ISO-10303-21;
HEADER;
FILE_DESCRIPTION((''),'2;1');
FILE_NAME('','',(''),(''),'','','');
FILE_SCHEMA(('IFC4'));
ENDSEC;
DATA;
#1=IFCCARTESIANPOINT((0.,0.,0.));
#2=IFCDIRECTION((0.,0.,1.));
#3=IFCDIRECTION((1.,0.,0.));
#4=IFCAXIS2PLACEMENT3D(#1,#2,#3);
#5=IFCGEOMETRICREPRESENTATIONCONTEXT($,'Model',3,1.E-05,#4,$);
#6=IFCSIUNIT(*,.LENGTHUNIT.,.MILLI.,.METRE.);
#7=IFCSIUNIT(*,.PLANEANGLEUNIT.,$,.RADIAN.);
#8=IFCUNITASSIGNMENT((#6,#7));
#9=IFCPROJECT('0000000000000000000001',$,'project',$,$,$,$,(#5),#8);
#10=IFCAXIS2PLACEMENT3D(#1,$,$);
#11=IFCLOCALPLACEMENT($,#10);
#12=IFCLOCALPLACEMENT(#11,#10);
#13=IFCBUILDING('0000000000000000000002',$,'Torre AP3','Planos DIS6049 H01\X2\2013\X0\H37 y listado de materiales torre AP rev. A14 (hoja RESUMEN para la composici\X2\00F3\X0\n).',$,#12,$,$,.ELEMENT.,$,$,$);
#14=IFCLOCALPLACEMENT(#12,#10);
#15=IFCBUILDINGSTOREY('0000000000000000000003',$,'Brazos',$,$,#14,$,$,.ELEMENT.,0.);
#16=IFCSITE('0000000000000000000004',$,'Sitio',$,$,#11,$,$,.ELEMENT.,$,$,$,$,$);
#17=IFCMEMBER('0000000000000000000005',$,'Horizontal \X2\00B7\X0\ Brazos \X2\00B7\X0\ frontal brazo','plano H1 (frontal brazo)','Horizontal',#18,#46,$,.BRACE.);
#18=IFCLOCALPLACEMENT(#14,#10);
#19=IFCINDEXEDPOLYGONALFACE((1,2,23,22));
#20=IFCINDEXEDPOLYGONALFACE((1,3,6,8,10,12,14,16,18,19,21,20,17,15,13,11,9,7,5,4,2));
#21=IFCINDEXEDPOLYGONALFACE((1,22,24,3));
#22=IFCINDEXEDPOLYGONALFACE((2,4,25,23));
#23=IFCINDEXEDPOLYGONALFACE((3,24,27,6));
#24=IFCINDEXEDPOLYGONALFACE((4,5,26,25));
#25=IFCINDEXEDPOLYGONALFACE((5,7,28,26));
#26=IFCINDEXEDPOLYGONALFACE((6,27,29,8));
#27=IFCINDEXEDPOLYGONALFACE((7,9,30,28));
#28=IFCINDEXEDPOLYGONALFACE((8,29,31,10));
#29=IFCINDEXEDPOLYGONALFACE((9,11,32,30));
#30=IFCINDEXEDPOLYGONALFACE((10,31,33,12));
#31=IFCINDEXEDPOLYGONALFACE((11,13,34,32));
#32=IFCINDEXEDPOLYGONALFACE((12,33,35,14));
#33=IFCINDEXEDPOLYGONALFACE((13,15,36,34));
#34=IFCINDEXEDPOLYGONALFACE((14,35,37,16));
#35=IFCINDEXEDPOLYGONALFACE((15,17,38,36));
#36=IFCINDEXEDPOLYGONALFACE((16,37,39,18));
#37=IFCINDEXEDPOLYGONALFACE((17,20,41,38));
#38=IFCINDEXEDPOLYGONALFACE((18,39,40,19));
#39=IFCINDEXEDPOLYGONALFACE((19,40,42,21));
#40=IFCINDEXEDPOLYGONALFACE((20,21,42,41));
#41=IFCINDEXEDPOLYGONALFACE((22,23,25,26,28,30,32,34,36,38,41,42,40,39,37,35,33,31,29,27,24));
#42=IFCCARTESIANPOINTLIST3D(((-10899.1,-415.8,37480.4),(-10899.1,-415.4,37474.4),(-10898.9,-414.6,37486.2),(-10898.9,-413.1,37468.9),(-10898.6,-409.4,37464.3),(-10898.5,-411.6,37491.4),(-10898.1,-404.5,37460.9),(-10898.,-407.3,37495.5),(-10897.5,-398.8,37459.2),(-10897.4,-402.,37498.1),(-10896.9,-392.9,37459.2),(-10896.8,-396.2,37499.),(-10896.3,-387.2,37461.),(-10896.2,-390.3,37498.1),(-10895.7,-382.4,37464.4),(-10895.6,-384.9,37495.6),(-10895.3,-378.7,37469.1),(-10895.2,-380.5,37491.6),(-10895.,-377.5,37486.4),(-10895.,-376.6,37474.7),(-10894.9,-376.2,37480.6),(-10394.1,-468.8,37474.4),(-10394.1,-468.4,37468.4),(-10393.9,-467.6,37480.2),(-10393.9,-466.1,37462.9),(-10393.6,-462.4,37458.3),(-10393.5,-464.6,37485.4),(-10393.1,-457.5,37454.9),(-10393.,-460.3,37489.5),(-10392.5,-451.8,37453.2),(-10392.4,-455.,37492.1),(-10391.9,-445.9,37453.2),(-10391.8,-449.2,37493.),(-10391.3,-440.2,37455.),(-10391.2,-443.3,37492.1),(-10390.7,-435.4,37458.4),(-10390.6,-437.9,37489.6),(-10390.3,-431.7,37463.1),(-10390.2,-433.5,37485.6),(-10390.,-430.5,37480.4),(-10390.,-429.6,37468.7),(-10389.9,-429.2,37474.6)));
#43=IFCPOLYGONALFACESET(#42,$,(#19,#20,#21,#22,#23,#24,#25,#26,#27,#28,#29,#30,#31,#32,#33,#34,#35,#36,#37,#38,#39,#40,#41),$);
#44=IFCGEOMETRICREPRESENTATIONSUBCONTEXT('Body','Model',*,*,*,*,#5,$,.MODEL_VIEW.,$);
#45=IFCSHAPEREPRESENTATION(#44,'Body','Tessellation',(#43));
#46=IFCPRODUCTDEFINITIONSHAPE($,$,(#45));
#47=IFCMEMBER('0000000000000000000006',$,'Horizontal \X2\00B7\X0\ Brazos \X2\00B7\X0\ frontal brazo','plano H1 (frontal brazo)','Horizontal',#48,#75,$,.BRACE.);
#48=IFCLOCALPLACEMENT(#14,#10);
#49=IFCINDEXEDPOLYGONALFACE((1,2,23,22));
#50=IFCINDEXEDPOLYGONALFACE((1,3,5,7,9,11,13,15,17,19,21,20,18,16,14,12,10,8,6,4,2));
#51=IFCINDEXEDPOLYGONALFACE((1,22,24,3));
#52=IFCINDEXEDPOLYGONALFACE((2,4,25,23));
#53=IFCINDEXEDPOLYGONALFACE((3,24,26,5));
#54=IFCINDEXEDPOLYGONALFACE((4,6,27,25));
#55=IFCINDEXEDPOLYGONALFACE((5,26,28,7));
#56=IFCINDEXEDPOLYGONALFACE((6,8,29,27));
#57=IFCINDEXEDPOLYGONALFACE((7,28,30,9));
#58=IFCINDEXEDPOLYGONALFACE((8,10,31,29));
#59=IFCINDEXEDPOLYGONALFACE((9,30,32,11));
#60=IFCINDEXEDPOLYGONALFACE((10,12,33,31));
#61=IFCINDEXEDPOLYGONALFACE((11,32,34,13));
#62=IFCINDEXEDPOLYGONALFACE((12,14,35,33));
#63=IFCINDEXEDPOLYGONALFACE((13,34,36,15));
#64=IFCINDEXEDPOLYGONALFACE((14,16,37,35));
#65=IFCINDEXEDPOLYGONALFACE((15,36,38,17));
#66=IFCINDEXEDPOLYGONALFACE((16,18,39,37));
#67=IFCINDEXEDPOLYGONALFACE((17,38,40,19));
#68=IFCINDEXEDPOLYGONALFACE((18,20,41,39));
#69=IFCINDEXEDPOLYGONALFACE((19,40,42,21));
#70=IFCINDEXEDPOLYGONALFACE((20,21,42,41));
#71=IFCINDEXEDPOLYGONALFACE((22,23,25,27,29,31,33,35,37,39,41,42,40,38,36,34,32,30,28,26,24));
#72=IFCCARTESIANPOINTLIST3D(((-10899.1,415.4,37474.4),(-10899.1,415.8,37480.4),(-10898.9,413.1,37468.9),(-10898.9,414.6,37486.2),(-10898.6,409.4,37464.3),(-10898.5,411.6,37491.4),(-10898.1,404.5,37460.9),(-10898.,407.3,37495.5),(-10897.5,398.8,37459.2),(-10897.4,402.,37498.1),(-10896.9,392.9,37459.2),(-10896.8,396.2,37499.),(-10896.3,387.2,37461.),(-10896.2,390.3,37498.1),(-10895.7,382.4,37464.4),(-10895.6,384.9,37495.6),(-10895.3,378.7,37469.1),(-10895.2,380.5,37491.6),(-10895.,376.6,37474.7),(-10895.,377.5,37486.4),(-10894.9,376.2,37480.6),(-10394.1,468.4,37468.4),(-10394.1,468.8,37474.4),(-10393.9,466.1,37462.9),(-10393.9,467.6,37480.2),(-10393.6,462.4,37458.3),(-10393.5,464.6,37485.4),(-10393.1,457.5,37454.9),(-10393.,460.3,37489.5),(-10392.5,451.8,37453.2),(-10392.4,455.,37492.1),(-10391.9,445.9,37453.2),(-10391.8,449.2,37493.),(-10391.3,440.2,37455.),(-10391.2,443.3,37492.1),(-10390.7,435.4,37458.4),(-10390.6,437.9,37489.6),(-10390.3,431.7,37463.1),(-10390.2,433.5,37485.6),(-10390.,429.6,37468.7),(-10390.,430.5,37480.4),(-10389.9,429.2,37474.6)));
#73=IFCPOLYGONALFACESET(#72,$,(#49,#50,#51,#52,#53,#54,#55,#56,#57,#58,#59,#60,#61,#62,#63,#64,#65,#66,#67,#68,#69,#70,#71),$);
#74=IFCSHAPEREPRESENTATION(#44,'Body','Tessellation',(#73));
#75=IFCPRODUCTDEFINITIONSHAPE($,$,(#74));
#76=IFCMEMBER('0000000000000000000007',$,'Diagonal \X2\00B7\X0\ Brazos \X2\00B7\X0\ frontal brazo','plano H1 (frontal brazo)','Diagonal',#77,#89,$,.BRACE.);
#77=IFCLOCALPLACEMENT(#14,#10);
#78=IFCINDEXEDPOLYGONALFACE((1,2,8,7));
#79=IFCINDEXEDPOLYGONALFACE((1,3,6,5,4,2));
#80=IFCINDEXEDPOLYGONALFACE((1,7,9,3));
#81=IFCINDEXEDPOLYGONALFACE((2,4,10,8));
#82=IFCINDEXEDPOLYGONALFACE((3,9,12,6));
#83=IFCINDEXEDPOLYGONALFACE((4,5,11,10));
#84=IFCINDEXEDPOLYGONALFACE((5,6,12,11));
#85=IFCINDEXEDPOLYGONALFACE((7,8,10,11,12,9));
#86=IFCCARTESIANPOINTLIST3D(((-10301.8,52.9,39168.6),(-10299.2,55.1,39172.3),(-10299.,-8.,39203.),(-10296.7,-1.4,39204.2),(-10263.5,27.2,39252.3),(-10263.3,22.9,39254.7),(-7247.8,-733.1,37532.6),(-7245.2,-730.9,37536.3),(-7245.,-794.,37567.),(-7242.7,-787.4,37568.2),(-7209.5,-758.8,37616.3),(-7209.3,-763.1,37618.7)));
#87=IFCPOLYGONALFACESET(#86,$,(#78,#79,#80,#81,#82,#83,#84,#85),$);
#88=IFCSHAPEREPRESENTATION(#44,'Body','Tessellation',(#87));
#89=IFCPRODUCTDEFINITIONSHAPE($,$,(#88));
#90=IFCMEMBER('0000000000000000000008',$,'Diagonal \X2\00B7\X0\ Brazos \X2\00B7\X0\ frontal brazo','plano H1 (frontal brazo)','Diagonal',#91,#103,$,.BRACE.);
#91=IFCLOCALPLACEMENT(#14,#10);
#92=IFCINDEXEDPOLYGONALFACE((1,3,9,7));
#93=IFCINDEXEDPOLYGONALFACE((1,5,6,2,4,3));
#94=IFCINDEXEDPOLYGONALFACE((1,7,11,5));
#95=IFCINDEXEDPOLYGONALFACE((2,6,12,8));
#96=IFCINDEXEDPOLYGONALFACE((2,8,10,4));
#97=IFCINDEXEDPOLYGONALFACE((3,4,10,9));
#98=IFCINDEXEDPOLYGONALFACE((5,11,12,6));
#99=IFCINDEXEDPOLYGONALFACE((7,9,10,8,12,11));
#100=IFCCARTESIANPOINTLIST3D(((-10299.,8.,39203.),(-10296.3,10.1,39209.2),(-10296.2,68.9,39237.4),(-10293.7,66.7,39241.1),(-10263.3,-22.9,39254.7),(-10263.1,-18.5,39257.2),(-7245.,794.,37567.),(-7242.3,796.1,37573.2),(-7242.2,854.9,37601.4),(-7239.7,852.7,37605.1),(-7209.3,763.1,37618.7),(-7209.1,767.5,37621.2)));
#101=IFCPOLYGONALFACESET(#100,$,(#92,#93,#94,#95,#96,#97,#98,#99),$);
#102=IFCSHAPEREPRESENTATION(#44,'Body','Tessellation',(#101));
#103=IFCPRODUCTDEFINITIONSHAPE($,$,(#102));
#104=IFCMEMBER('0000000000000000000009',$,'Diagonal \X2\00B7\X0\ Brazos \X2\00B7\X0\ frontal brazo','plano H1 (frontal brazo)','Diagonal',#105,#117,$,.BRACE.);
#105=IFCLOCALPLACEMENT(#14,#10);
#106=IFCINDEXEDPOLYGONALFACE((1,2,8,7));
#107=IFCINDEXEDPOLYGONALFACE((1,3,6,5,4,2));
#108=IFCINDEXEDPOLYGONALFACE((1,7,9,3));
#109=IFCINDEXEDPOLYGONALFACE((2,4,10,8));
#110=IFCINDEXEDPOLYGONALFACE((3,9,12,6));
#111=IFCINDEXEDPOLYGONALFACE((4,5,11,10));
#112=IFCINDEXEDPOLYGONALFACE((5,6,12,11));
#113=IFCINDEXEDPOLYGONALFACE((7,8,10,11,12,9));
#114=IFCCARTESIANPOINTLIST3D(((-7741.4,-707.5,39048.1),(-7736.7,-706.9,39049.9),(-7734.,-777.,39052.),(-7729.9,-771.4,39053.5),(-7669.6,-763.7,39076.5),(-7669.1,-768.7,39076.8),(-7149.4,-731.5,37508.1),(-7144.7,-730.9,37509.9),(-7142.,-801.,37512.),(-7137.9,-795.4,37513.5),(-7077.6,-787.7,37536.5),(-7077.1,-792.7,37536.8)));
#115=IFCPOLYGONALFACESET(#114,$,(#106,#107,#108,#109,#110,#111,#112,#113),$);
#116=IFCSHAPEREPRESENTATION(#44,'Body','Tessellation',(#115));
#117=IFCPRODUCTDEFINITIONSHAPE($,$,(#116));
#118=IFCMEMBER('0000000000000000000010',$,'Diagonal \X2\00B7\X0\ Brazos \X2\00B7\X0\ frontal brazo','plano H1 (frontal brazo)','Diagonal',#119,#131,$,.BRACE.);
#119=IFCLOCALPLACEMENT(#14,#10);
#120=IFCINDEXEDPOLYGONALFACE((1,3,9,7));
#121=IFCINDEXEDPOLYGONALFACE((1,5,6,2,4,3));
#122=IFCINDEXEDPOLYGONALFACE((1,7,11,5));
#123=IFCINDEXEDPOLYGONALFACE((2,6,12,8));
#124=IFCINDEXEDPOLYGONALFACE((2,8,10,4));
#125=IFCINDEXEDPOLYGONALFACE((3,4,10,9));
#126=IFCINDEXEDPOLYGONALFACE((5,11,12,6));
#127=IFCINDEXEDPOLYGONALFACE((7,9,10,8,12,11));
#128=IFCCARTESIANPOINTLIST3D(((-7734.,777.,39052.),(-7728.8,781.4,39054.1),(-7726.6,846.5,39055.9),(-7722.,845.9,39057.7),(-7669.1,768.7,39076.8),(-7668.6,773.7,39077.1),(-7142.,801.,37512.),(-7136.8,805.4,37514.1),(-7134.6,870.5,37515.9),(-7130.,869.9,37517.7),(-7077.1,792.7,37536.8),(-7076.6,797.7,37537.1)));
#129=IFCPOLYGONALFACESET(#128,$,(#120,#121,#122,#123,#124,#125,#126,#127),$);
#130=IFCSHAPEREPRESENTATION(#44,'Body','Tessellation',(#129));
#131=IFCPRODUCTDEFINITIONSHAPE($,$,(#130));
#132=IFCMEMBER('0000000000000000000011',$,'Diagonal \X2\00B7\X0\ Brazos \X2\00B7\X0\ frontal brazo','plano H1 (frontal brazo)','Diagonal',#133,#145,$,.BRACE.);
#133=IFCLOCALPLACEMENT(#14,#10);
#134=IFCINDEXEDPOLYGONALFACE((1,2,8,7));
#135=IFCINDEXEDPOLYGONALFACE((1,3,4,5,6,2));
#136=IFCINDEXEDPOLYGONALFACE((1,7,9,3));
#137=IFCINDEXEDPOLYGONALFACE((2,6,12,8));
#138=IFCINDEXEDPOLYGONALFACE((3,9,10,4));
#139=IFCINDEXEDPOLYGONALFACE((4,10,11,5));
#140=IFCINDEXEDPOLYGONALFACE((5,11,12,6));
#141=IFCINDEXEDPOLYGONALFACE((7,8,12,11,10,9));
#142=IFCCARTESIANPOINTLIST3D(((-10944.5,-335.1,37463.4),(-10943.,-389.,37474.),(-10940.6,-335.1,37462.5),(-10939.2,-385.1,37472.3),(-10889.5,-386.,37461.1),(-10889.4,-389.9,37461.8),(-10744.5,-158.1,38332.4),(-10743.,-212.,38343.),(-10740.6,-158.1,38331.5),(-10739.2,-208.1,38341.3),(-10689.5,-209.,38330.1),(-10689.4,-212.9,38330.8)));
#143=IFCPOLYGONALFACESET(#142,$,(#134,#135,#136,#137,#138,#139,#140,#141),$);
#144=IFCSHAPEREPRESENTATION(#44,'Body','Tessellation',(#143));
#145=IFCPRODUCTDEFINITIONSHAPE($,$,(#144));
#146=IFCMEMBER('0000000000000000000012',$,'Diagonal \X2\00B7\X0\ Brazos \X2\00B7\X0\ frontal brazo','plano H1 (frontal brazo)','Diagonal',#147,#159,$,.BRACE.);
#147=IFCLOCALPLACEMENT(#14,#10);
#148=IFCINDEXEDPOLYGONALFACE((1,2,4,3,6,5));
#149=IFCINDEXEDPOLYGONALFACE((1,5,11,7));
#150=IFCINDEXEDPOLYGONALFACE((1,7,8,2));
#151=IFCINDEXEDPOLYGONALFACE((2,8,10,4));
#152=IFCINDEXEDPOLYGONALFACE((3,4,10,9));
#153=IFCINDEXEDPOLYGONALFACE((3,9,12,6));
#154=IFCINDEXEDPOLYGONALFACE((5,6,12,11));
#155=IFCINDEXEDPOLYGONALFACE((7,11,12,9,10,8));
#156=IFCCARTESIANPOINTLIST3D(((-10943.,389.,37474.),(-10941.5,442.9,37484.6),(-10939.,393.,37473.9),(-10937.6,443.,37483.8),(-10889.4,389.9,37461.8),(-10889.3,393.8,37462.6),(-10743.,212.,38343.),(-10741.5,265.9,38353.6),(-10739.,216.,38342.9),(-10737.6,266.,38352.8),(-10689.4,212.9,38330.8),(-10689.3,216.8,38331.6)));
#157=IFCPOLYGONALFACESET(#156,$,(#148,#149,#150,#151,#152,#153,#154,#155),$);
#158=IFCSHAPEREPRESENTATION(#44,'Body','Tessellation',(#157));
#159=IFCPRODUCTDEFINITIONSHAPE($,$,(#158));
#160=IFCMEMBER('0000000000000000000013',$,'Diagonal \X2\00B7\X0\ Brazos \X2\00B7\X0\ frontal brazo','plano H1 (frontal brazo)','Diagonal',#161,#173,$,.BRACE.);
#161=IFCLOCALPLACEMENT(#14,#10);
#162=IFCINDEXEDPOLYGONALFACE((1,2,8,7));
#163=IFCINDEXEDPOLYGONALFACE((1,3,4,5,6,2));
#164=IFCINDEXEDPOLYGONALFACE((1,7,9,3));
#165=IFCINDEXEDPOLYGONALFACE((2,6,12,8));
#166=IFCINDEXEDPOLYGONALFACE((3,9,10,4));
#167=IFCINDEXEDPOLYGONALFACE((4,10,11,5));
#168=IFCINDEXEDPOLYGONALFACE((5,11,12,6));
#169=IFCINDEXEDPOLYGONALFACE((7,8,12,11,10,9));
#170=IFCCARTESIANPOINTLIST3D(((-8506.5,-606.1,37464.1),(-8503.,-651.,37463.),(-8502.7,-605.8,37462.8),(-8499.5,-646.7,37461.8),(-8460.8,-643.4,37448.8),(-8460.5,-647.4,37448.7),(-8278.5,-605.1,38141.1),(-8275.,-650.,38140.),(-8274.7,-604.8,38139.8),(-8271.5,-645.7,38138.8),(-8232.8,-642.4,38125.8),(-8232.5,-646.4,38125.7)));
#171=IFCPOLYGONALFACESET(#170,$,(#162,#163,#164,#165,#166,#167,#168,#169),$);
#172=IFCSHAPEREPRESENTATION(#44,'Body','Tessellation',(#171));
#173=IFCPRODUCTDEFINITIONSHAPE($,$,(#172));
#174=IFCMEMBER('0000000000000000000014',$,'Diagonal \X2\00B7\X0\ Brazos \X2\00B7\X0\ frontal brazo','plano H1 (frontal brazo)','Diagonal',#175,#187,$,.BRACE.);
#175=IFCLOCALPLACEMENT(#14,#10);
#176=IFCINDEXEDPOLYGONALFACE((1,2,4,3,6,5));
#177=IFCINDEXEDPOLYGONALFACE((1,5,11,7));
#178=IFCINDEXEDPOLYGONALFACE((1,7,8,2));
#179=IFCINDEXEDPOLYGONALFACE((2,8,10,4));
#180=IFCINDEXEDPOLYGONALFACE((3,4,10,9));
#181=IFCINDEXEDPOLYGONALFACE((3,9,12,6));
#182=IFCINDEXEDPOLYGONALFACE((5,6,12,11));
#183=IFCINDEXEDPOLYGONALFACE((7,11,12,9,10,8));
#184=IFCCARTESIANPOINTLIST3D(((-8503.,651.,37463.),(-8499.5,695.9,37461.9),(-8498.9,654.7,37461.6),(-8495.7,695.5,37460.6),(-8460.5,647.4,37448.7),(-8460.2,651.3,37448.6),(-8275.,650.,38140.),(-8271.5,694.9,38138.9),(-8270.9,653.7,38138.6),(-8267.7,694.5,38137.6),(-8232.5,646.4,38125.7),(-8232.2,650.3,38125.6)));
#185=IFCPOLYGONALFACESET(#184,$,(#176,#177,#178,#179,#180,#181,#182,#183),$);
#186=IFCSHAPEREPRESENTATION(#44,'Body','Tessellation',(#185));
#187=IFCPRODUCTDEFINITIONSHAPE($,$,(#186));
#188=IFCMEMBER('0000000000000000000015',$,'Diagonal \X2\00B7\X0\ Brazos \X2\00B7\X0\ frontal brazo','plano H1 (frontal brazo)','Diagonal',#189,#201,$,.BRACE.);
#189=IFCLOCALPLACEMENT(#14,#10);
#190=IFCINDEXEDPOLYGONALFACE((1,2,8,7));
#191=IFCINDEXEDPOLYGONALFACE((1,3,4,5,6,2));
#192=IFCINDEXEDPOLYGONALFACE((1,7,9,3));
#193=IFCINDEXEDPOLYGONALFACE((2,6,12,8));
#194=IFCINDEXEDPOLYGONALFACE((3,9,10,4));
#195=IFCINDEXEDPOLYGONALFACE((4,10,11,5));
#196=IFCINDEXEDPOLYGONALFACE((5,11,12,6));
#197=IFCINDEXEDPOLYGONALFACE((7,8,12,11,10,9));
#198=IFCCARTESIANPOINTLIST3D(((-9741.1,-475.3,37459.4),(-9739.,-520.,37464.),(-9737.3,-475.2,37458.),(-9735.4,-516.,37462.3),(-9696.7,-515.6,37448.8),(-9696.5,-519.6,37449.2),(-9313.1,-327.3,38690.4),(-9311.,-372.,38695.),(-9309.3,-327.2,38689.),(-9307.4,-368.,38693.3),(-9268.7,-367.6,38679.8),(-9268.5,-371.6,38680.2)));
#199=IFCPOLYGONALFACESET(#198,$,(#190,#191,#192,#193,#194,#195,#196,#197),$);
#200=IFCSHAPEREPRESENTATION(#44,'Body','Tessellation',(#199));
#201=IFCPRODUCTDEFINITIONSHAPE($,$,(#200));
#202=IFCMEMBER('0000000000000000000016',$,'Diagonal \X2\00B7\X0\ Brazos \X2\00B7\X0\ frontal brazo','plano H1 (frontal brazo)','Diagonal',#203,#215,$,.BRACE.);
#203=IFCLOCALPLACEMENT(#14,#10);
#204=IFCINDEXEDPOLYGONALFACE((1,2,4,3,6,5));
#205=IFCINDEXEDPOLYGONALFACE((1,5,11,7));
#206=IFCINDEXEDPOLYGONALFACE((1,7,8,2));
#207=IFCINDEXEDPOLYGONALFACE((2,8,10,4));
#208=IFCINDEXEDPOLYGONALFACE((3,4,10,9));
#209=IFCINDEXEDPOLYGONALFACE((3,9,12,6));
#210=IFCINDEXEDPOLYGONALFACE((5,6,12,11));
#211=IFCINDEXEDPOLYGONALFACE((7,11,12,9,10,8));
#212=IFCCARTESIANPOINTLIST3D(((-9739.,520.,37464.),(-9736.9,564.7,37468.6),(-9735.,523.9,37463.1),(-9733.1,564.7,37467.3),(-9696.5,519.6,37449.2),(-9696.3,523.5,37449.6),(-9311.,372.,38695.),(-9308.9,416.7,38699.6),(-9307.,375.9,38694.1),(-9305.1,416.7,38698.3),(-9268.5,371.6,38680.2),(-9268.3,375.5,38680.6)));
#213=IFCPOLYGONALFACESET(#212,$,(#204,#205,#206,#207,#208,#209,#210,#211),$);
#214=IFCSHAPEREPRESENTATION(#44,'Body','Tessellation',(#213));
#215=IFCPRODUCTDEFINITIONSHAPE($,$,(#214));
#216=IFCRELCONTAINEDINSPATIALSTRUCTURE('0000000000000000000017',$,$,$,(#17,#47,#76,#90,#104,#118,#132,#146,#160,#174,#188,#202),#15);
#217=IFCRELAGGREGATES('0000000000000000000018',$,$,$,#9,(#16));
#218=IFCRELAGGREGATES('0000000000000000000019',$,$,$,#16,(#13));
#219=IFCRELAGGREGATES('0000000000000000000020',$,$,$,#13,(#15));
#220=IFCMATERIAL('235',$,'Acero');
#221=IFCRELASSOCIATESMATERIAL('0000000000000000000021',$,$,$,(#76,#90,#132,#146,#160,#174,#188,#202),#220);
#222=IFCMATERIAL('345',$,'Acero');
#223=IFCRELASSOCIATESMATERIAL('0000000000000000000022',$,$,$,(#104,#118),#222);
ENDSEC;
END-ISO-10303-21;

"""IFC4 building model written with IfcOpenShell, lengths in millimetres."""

from ifc_helpers import new_model, si_unit, frame, frame_2d, origin, origin_with_axes, place, context, subcontext, project, spatial, circle, l_section, extrude, material, element, save


model = new_model("IFC4")

# Units and contexts
model_context = context("Model", 3, precision=1e-05, world=origin_with_axes())
body_context = subcontext(model_context, "Body", "Model", "MODEL_VIEW")
ifc_project = project(units=[si_unit("LENGTHUNIT", "METRE", prefix="MILLI"), si_unit("PLANEANGLEUNIT", "RADIAN")], contexts=[model_context])

# Site, building, storey
site_placement = place(None, origin())
site = spatial("IfcSite", under=ifc_project, at=site_placement, Name="Sitio", CompositionType="ELEMENT")
building_placement = place(site_placement, origin())
building = spatial("IfcBuilding", under=site, at=building_placement, Name="Torre AP3", Description="Planos DIS6049 H01–H37 y listado de materiales torre AP rev. A14 (hoja RESUMEN para la composición).", CompositionType="ELEMENT")
storey_placement = place(building_placement, origin())
storey = spatial("IfcBuildingStorey", under=building, at=storey_placement, Name="Brazos", CompositionType="ELEMENT", Elevation=0.0)

# Members
for number, where, z_axis, x_axis, name in (
    (1, (-10392.0, -449.0, 37473.0), (-0.994468, 0.10437, 0.011815), (0.104986, 0.991163, 0.081074), "Horizontal · Brazos · frontal brazo"),
    (2, (-10392.0, 449.0, 37473.0), (-0.994468, -0.10437, 0.011815), (0.104986, -0.991163, 0.081074), "Horizontal · Brazos · frontal brazo"),
):
    element("IfcMember", number, at=place(storey_placement, frame(where, z_axis=z_axis, x_axis=x_axis)), inside=storey, Name=name, Description="plano H1 (frontal brazo)", ObjectType="Horizontal", PredefinedType="BRACE", context=body_context, shape_type="SweptSolid", body=[
        extrude(circle(Radius=20.0), None, (0.0, 0.0, 1.0), 507.8),
    ])
ifc_material_1 = material(Name="235", Category="Acero")
for number, where, z_axis, x_axis, name in (
    (3, (-7245.0, -794.0, 37567.0), (-0.859644, 0.221244, 0.460503), (0.509345, 0.441284, 0.738808), "Diagonal · Brazos · frontal brazo"),
    (4, (-7245.0, 794.0, 37567.0), (-0.859644, -0.221244, 0.460503), (0.509345, -0.441284, 0.738808), "Diagonal · Brazos · frontal brazo"),
):
    element("IfcMember", number, at=place(storey_placement, frame(where, z_axis=z_axis, x_axis=x_axis)), inside=storey, material=ifc_material_1, Name=name, Description="plano H1 (frontal brazo)", ObjectType="Diagonal", PredefinedType="BRACE", context=body_context, shape_type="SweptSolid", body=[
        extrude(l_section(Depth=70.0, Width=70.0, Thickness=5.0, at=frame_2d((35.0, 35.0))), None, (0.0, 0.0, 1.0), 3552.6),
    ])
ifc_material_2 = material(Name="345", Category="Acero")
for number, where, z_axis, x_axis, name in (
    (5, (-7142.0, -801.0, 37512.0), (-0.358779, 0.014545, 0.933309), (0.927462, 0.118373, 0.354686), "Diagonal · Brazos · frontal brazo"),
    (6, (-7142.0, 801.0, 37512.0), (-0.358779, -0.014545, 0.933309), (0.927462, -0.118373, 0.354686), "Diagonal · Brazos · frontal brazo"),
):
    element("IfcMember", number, at=place(storey_placement, frame(where, z_axis=z_axis, x_axis=x_axis)), inside=storey, material=ifc_material_2, Name=name, Description="plano H1 (frontal brazo)", ObjectType="Diagonal", PredefinedType="BRACE", context=body_context, shape_type="SweptSolid", body=[
        extrude(l_section(Depth=70.0, Width=70.0, Thickness=5.0, at=frame_2d((35.0, 35.0))), None, (0.0, 0.0, 1.0), 1650.0),
    ])
for number, where, z_axis, x_axis, name in (
    (7, (-10943.0, -389.0, 37474.0), (0.219994, 0.194695, 0.955875), (0.975122, -0.016589, -0.221045), "Diagonal · Brazos · frontal brazo"),
    (8, (-10943.0, 389.0, 37474.0), (0.219994, -0.194695, 0.955875), (0.975122, 0.016589, -0.221045), "Diagonal · Brazos · frontal brazo"),
):
    element("IfcMember", number, at=place(storey_placement, frame(where, z_axis=z_axis, x_axis=x_axis)), inside=storey, material=ifc_material_1, Name=name, Description="plano H1 (frontal brazo)", ObjectType="Diagonal", PredefinedType="BRACE", context=body_context, shape_type="SweptSolid", body=[
        extrude(l_section(Depth=55.0, Width=55.0, Thickness=4.0, at=frame_2d((27.5, 27.5))), None, (0.0, 0.0, 1.0), 909.1),
    ])
for number, where, z_axis, x_axis, name in (
    (9, (-8503.0, -651.0, 37463.0), (0.319166, 0.0014, 0.947698), (0.944542, 0.081082, -0.318223), "Diagonal · Brazos · frontal brazo"),
    (10, (-8503.0, 651.0, 37463.0), (0.319166, -0.0014, 0.947698), (0.944542, -0.081082, -0.318223), "Diagonal · Brazos · frontal brazo"),
):
    element("IfcMember", number, at=place(storey_placement, frame(where, z_axis=z_axis, x_axis=x_axis)), inside=storey, material=ifc_material_1, Name=name, Description="plano H1 (frontal brazo)", ObjectType="Diagonal", PredefinedType="BRACE", context=body_context, shape_type="SweptSolid", body=[
        extrude(l_section(Depth=45.0, Width=45.0, Thickness=4.0, at=frame_2d((22.5, 22.5))), None, (0.0, 0.0, 1.0), 714.4),
    ])
for number, where, z_axis, x_axis, name in (
    (11, (-9739.0, -520.0, 37464.0), (0.326304, 0.112834, 0.938506), (0.944119, 0.009962, -0.329454), "Diagonal · Brazos · frontal brazo"),
    (12, (-9739.0, 520.0, 37464.0), (0.326304, -0.112834, 0.938506), (0.944119, -0.009962, -0.329454), "Diagonal · Brazos · frontal brazo"),
):
    element("IfcMember", number, at=place(storey_placement, frame(where, z_axis=z_axis, x_axis=x_axis)), inside=storey, material=ifc_material_1, Name=name, Description="plano H1 (frontal brazo)", ObjectType="Diagonal", PredefinedType="BRACE", context=body_context, shape_type="SweptSolid", body=[
        extrude(l_section(Depth=45.0, Width=45.0, Thickness=4.0, at=frame_2d((22.5, 22.5))), None, (0.0, 0.0, 1.0), 1311.7),
    ])

save(model, "model.ifc")
